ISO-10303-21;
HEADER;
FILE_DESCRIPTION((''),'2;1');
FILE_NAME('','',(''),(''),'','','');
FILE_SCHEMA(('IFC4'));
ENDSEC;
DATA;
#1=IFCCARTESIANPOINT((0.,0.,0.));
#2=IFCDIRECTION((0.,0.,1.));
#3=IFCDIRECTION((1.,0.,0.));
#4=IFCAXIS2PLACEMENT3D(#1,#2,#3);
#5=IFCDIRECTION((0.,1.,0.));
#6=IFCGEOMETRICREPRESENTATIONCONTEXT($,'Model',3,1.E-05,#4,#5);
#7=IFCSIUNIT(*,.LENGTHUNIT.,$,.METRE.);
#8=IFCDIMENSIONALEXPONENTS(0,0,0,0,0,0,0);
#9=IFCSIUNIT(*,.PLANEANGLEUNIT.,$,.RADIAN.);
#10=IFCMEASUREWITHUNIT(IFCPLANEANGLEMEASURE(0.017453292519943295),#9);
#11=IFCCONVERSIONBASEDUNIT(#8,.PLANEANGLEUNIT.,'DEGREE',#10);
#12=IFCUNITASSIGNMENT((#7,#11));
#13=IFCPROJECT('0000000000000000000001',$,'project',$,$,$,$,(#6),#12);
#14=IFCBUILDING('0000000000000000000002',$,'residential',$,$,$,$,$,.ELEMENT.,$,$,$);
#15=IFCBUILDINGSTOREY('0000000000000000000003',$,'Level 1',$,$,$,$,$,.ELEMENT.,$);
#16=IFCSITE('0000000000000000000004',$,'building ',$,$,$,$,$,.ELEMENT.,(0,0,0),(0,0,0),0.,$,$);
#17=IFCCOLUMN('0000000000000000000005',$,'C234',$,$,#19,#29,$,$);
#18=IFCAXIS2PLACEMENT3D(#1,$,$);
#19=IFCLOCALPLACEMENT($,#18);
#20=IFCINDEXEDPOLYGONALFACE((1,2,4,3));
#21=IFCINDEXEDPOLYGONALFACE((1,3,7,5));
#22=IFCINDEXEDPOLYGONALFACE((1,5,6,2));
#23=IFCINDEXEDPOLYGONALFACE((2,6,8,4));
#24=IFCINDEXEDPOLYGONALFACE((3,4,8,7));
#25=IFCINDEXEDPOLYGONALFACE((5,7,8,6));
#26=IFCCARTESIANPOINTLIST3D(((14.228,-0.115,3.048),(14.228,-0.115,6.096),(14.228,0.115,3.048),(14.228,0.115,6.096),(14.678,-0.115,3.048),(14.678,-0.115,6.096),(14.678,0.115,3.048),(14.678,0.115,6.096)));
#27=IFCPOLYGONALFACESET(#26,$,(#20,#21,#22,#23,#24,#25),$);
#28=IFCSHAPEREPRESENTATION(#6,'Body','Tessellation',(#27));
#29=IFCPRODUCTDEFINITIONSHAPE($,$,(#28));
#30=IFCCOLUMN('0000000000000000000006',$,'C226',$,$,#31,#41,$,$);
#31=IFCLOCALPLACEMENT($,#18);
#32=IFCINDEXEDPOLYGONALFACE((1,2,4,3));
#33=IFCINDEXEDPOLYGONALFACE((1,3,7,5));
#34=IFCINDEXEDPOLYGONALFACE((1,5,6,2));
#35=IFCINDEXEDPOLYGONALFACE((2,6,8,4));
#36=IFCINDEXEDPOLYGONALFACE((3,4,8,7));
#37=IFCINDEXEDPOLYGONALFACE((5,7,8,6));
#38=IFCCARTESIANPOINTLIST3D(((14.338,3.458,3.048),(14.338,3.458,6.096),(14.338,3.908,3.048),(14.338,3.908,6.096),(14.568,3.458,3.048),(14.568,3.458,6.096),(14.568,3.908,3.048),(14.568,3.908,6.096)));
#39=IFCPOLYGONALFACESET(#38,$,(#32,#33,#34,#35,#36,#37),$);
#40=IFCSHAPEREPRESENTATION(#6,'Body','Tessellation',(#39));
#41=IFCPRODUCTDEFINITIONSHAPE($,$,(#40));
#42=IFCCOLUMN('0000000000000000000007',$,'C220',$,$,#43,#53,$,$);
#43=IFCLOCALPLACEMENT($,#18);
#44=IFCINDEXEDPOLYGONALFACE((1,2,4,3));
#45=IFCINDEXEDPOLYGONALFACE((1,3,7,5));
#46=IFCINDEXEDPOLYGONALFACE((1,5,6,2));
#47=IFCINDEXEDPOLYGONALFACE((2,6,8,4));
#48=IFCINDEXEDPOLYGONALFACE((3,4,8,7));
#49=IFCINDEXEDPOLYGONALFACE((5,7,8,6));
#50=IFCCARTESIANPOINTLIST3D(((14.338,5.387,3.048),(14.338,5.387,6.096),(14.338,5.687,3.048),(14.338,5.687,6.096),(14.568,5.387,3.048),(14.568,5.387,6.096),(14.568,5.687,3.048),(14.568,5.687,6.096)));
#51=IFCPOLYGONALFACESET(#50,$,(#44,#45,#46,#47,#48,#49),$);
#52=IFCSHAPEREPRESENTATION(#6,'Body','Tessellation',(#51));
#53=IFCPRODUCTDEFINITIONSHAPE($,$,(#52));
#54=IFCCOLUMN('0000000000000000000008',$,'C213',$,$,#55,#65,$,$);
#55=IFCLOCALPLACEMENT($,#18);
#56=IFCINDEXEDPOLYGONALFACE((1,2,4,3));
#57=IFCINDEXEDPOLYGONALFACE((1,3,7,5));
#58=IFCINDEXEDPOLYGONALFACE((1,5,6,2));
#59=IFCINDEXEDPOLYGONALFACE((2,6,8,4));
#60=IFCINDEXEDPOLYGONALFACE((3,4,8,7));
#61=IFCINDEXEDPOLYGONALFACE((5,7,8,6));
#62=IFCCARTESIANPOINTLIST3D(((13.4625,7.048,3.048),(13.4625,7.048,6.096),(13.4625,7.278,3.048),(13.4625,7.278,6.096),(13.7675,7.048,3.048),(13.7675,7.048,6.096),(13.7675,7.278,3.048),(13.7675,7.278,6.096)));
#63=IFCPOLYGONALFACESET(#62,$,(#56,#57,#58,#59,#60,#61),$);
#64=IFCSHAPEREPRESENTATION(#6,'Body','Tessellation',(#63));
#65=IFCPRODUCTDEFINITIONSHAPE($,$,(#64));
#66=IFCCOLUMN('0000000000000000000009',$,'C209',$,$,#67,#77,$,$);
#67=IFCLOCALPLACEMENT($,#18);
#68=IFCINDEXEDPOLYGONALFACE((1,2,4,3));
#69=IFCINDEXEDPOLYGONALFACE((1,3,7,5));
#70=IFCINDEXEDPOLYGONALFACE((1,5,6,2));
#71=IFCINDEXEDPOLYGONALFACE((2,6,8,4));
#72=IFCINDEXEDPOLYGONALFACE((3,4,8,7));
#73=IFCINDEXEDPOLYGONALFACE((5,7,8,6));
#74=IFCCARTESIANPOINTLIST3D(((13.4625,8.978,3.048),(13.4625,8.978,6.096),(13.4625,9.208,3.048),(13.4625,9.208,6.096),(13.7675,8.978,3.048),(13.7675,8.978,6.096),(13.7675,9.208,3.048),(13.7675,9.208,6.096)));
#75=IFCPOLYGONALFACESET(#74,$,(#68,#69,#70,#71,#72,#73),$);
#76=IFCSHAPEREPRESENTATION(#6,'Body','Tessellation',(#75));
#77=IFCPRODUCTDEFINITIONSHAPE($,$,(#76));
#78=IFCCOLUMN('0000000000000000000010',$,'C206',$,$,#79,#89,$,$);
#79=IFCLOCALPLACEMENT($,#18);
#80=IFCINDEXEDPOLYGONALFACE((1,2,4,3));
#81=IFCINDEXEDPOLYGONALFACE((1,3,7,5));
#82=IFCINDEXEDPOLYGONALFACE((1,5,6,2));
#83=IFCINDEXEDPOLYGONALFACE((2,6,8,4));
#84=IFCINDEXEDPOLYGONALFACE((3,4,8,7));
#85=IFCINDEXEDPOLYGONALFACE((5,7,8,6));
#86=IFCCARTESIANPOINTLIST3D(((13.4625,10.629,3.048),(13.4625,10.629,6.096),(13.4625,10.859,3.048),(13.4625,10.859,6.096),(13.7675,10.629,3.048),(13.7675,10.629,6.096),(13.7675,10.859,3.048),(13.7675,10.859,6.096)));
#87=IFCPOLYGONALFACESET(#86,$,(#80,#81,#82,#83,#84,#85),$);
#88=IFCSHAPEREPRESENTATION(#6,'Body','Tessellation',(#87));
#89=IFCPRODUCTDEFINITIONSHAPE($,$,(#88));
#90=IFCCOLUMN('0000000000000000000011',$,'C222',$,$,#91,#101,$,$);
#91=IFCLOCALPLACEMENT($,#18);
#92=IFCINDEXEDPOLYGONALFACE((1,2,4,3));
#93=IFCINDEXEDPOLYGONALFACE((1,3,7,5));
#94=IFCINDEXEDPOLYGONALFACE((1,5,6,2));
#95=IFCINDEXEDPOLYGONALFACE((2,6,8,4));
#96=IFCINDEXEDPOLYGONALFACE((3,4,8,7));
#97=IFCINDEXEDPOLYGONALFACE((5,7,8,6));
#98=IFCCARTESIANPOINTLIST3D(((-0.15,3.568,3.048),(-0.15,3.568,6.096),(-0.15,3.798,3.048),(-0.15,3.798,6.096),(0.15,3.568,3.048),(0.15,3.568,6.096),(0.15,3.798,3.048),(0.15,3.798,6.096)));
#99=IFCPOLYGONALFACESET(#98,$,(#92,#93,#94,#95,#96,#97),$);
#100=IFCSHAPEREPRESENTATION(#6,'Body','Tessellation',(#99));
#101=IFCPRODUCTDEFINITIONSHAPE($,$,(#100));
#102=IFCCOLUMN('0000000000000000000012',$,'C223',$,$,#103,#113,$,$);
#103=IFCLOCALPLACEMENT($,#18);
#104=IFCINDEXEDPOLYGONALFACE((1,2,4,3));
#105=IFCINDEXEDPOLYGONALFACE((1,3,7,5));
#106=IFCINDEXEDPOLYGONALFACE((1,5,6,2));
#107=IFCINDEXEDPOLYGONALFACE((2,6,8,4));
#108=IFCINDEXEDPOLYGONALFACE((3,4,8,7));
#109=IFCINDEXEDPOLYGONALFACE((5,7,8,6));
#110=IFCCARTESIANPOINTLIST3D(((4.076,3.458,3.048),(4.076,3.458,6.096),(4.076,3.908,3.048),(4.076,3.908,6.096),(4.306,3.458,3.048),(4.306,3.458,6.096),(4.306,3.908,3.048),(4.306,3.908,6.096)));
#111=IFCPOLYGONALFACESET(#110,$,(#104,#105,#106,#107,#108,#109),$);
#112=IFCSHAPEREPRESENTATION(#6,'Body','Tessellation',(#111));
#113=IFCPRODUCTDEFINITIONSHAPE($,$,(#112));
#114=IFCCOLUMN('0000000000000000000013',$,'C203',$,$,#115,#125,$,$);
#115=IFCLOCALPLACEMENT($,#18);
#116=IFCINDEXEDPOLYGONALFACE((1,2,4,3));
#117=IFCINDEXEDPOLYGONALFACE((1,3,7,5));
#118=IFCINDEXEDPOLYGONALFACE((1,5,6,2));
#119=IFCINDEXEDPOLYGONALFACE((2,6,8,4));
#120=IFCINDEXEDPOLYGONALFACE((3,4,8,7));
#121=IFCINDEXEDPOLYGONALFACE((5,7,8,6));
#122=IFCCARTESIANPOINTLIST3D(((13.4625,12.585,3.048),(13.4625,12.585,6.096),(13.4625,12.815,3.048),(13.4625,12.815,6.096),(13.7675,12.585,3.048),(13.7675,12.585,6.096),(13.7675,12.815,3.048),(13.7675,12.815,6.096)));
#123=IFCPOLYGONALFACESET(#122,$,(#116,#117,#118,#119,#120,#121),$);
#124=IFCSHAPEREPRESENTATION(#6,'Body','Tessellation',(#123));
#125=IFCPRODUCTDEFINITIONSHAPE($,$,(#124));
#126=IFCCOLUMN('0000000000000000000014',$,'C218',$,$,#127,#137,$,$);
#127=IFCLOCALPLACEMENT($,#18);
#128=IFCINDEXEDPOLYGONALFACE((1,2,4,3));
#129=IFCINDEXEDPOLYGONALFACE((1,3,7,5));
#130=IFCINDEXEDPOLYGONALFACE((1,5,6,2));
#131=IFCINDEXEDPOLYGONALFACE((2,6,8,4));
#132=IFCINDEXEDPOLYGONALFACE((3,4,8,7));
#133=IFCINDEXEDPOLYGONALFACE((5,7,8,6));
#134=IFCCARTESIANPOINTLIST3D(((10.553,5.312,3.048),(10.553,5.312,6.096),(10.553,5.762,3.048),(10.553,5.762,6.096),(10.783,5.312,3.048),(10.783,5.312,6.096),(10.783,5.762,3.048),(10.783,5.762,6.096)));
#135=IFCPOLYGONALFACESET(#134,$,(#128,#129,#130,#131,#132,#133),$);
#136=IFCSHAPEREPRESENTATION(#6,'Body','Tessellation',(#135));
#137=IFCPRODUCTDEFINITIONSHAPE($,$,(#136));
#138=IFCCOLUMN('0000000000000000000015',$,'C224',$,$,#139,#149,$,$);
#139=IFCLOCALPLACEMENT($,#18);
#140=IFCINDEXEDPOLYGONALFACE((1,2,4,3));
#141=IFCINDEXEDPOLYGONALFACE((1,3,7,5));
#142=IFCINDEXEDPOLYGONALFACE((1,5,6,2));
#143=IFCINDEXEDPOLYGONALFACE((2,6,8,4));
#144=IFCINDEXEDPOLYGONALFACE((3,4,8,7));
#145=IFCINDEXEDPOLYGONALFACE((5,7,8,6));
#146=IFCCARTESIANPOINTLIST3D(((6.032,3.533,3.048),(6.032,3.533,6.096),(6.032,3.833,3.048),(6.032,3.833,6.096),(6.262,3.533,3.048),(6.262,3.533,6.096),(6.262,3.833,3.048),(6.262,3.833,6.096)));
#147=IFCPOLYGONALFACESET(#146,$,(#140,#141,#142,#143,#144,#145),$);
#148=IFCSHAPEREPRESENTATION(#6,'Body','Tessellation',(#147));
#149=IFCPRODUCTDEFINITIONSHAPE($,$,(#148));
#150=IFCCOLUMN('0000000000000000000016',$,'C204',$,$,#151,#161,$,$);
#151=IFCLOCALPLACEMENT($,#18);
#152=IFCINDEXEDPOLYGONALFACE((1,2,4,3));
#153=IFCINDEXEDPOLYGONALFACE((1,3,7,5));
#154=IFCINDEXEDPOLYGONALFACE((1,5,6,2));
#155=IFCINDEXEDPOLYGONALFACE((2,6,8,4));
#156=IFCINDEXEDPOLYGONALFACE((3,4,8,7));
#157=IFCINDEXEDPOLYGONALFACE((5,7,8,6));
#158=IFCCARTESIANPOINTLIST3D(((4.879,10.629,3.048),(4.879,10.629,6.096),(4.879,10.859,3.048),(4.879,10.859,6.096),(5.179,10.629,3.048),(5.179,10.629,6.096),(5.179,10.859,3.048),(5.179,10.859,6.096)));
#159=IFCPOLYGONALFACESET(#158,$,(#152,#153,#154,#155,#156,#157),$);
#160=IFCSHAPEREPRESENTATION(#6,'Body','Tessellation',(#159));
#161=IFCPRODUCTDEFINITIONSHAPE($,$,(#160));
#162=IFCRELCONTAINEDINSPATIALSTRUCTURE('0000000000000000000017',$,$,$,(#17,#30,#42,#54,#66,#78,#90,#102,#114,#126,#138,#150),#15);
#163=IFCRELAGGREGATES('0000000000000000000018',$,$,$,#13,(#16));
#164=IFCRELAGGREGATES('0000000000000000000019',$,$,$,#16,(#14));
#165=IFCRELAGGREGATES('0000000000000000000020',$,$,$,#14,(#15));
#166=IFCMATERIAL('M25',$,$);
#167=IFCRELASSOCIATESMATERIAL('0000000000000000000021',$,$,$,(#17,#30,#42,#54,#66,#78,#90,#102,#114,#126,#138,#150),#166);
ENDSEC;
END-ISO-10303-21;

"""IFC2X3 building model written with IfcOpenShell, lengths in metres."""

from ifc_helpers import new_model, entity, si_unit, converted_unit, direction, frame, frame_2d, origin_with_axes, place, context, project, spatial, rectangle, extrude, material, element, save


model = new_model("IFC2X3")

# Units and contexts
model_context = context("Model", 3, precision=1e-05, world=origin_with_axes(), true_north=direction((0.0, 1.0, 0.0)))
ifc_project = project(units=[si_unit("LENGTHUNIT", "METRE"), converted_unit("PLANEANGLEUNIT", "DEGREE", entity("IfcPlaneAngleMeasure", 0.017453292519943295), si_unit("PLANEANGLEUNIT", "RADIAN"), dimensions=[0, 0, 0, 0, 0, 0, 0])], contexts=[model_context])

# Site, building, storey
site = spatial("IfcSite", under=ifc_project, Name="building ", CompositionType="ELEMENT", RefLatitude=(0, 0, 0), RefLongitude=(0, 0, 0), RefElevation=0.0)
building = spatial("IfcBuilding", under=site, Name="residential", CompositionType="ELEMENT")
storey = spatial("IfcBuildingStorey", under=building, Name="Level 1", CompositionType="ELEMENT")

# Columns
ifc_material = material(Name="M25")
placement = place(None, origin_with_axes())
element("IfcColumn", 1, at=placement, inside=storey, material=ifc_material, Name="C234", context=model_context, shape_type="SweptSolid", body=[
    extrude(rectangle(XDim=0.45, YDim=0.23, at=frame_2d((0.0, 0.0), x_axis=(1.0, 0.0, 0.0))), frame((14.453, 0.0, 3.048), z_axis=(0.0, 0.0, 1.0), x_axis=(1.0, 0.0, 0.0)), (0.0, 0.0, 1.0), 3.048),
])
element("IfcColumn", 2, at=placement, inside=storey, material=ifc_material, Name="C226", context=model_context, shape_type="SweptSolid", body=[
    extrude(rectangle(XDim=0.23, YDim=0.45, at=frame_2d((0.0, 0.0), x_axis=(1.0, 0.0, 0.0))), frame((14.453, 3.683, 3.048), z_axis=(0.0, 0.0, 1.0), x_axis=(1.0, 0.0, 0.0)), (0.0, 0.0, 1.0), 3.048),
])
element("IfcColumn", 3, at=placement, inside=storey, material=ifc_material, Name="C220", context=model_context, shape_type="SweptSolid", body=[
    extrude(rectangle(XDim=0.23, YDim=0.3, at=frame_2d((0.0, 0.0), x_axis=(1.0, 0.0, 0.0))), frame((14.453, 5.537, 3.048), z_axis=(0.0, 0.0, 1.0), x_axis=(1.0, 0.0, 0.0)), (0.0, 0.0, 1.0), 3.048),
])
element("IfcColumn", 4, at=placement, inside=storey, material=ifc_material, Name="C213", context=model_context, shape_type="SweptSolid", body=[
    extrude(rectangle(XDim=0.305, YDim=0.23, at=frame_2d((0.0, 0.0), x_axis=(1.0, 0.0, 0.0))), frame((13.615, 7.163, 3.048), z_axis=(0.0, 0.0, 1.0), x_axis=(1.0, 0.0, 0.0)), (0.0, 0.0, 1.0), 3.048),
])
element("IfcColumn", 5, at=placement, inside=storey, material=ifc_material, Name="C209", context=model_context, shape_type="SweptSolid", body=[
    extrude(rectangle(XDim=0.305, YDim=0.23, at=frame_2d((0.0, 0.0), x_axis=(1.0, 0.0, 0.0))), frame((13.615, 9.093, 3.048), z_axis=(0.0, 0.0, 1.0), x_axis=(1.0, 0.0, 0.0)), (0.0, 0.0, 1.0), 3.048),
])
element("IfcColumn", 6, at=placement, inside=storey, material=ifc_material, Name="C206", context=model_context, shape_type="SweptSolid", body=[
    extrude(rectangle(XDim=0.305, YDim=0.23, at=frame_2d((0.0, 0.0), x_axis=(1.0, 0.0, 0.0))), frame((13.615, 10.744, 3.048), z_axis=(0.0, 0.0, 1.0), x_axis=(1.0, 0.0, 0.0)), (0.0, 0.0, 1.0), 3.048),
])
element("IfcColumn", 7, at=placement, inside=storey, material=ifc_material, Name="C222", context=model_context, shape_type="SweptSolid", body=[
    extrude(rectangle(XDim=0.3, YDim=0.23, at=frame_2d((0.0, 0.0), x_axis=(1.0, 0.0, 0.0))), frame((0.0, 3.683, 3.048), z_axis=(0.0, 0.0, 1.0), x_axis=(1.0, 0.0, 0.0)), (0.0, 0.0, 1.0), 3.048),
])
element("IfcColumn", 8, at=placement, inside=storey, material=ifc_material, Name="C223", context=model_context, shape_type="SweptSolid", body=[
    extrude(rectangle(XDim=0.23, YDim=0.45, at=frame_2d((0.0, 0.0), x_axis=(1.0, 0.0, 0.0))), frame((4.191, 3.683, 3.048), z_axis=(0.0, 0.0, 1.0), x_axis=(1.0, 0.0, 0.0)), (0.0, 0.0, 1.0), 3.048),
])
element("IfcColumn", 9, at=placement, inside=storey, material=ifc_material, Name="C203", context=model_context, shape_type="SweptSolid", body=[
    extrude(rectangle(XDim=0.305, YDim=0.23, at=frame_2d((0.0, 0.0), x_axis=(1.0, 0.0, 0.0))), frame((13.615, 12.7, 3.048), z_axis=(0.0, 0.0, 1.0), x_axis=(1.0, 0.0, 0.0)), (0.0, 0.0, 1.0), 3.048),
])
element("IfcColumn", 10, at=placement, inside=storey, material=ifc_material, Name="C218", context=model_context, shape_type="SweptSolid", body=[
    extrude(rectangle(XDim=0.23, YDim=0.45, at=frame_2d((0.0, 0.0), x_axis=(1.0, 0.0, 0.0))), frame((10.668, 5.537, 3.048), z_axis=(0.0, 0.0, 1.0), x_axis=(1.0, 0.0, 0.0)), (0.0, 0.0, 1.0), 3.048),
])
element("IfcColumn", 11, at=placement, inside=storey, material=ifc_material, Name="C224", context=model_context, shape_type="SweptSolid", body=[
    extrude(rectangle(XDim=0.23, YDim=0.3, at=frame_2d((0.0, 0.0), x_axis=(1.0, 0.0, 0.0))), frame((6.147, 3.683, 3.048), z_axis=(0.0, 0.0, 1.0), x_axis=(1.0, 0.0, 0.0)), (0.0, 0.0, 1.0), 3.048),
])
element("IfcColumn", 12, at=placement, inside=storey, material=ifc_material, Name="C204", context=model_context, shape_type="SweptSolid", body=[
    extrude(rectangle(XDim=0.3, YDim=0.23, at=frame_2d((0.0, 0.0), x_axis=(1.0, 0.0, 0.0))), frame((5.029, 10.744, 3.048), z_axis=(0.0, 0.0, 1.0), x_axis=(1.0, 0.0, 0.0)), (0.0, 0.0, 1.0), 3.048),
])

save(model, "model.ifc")
